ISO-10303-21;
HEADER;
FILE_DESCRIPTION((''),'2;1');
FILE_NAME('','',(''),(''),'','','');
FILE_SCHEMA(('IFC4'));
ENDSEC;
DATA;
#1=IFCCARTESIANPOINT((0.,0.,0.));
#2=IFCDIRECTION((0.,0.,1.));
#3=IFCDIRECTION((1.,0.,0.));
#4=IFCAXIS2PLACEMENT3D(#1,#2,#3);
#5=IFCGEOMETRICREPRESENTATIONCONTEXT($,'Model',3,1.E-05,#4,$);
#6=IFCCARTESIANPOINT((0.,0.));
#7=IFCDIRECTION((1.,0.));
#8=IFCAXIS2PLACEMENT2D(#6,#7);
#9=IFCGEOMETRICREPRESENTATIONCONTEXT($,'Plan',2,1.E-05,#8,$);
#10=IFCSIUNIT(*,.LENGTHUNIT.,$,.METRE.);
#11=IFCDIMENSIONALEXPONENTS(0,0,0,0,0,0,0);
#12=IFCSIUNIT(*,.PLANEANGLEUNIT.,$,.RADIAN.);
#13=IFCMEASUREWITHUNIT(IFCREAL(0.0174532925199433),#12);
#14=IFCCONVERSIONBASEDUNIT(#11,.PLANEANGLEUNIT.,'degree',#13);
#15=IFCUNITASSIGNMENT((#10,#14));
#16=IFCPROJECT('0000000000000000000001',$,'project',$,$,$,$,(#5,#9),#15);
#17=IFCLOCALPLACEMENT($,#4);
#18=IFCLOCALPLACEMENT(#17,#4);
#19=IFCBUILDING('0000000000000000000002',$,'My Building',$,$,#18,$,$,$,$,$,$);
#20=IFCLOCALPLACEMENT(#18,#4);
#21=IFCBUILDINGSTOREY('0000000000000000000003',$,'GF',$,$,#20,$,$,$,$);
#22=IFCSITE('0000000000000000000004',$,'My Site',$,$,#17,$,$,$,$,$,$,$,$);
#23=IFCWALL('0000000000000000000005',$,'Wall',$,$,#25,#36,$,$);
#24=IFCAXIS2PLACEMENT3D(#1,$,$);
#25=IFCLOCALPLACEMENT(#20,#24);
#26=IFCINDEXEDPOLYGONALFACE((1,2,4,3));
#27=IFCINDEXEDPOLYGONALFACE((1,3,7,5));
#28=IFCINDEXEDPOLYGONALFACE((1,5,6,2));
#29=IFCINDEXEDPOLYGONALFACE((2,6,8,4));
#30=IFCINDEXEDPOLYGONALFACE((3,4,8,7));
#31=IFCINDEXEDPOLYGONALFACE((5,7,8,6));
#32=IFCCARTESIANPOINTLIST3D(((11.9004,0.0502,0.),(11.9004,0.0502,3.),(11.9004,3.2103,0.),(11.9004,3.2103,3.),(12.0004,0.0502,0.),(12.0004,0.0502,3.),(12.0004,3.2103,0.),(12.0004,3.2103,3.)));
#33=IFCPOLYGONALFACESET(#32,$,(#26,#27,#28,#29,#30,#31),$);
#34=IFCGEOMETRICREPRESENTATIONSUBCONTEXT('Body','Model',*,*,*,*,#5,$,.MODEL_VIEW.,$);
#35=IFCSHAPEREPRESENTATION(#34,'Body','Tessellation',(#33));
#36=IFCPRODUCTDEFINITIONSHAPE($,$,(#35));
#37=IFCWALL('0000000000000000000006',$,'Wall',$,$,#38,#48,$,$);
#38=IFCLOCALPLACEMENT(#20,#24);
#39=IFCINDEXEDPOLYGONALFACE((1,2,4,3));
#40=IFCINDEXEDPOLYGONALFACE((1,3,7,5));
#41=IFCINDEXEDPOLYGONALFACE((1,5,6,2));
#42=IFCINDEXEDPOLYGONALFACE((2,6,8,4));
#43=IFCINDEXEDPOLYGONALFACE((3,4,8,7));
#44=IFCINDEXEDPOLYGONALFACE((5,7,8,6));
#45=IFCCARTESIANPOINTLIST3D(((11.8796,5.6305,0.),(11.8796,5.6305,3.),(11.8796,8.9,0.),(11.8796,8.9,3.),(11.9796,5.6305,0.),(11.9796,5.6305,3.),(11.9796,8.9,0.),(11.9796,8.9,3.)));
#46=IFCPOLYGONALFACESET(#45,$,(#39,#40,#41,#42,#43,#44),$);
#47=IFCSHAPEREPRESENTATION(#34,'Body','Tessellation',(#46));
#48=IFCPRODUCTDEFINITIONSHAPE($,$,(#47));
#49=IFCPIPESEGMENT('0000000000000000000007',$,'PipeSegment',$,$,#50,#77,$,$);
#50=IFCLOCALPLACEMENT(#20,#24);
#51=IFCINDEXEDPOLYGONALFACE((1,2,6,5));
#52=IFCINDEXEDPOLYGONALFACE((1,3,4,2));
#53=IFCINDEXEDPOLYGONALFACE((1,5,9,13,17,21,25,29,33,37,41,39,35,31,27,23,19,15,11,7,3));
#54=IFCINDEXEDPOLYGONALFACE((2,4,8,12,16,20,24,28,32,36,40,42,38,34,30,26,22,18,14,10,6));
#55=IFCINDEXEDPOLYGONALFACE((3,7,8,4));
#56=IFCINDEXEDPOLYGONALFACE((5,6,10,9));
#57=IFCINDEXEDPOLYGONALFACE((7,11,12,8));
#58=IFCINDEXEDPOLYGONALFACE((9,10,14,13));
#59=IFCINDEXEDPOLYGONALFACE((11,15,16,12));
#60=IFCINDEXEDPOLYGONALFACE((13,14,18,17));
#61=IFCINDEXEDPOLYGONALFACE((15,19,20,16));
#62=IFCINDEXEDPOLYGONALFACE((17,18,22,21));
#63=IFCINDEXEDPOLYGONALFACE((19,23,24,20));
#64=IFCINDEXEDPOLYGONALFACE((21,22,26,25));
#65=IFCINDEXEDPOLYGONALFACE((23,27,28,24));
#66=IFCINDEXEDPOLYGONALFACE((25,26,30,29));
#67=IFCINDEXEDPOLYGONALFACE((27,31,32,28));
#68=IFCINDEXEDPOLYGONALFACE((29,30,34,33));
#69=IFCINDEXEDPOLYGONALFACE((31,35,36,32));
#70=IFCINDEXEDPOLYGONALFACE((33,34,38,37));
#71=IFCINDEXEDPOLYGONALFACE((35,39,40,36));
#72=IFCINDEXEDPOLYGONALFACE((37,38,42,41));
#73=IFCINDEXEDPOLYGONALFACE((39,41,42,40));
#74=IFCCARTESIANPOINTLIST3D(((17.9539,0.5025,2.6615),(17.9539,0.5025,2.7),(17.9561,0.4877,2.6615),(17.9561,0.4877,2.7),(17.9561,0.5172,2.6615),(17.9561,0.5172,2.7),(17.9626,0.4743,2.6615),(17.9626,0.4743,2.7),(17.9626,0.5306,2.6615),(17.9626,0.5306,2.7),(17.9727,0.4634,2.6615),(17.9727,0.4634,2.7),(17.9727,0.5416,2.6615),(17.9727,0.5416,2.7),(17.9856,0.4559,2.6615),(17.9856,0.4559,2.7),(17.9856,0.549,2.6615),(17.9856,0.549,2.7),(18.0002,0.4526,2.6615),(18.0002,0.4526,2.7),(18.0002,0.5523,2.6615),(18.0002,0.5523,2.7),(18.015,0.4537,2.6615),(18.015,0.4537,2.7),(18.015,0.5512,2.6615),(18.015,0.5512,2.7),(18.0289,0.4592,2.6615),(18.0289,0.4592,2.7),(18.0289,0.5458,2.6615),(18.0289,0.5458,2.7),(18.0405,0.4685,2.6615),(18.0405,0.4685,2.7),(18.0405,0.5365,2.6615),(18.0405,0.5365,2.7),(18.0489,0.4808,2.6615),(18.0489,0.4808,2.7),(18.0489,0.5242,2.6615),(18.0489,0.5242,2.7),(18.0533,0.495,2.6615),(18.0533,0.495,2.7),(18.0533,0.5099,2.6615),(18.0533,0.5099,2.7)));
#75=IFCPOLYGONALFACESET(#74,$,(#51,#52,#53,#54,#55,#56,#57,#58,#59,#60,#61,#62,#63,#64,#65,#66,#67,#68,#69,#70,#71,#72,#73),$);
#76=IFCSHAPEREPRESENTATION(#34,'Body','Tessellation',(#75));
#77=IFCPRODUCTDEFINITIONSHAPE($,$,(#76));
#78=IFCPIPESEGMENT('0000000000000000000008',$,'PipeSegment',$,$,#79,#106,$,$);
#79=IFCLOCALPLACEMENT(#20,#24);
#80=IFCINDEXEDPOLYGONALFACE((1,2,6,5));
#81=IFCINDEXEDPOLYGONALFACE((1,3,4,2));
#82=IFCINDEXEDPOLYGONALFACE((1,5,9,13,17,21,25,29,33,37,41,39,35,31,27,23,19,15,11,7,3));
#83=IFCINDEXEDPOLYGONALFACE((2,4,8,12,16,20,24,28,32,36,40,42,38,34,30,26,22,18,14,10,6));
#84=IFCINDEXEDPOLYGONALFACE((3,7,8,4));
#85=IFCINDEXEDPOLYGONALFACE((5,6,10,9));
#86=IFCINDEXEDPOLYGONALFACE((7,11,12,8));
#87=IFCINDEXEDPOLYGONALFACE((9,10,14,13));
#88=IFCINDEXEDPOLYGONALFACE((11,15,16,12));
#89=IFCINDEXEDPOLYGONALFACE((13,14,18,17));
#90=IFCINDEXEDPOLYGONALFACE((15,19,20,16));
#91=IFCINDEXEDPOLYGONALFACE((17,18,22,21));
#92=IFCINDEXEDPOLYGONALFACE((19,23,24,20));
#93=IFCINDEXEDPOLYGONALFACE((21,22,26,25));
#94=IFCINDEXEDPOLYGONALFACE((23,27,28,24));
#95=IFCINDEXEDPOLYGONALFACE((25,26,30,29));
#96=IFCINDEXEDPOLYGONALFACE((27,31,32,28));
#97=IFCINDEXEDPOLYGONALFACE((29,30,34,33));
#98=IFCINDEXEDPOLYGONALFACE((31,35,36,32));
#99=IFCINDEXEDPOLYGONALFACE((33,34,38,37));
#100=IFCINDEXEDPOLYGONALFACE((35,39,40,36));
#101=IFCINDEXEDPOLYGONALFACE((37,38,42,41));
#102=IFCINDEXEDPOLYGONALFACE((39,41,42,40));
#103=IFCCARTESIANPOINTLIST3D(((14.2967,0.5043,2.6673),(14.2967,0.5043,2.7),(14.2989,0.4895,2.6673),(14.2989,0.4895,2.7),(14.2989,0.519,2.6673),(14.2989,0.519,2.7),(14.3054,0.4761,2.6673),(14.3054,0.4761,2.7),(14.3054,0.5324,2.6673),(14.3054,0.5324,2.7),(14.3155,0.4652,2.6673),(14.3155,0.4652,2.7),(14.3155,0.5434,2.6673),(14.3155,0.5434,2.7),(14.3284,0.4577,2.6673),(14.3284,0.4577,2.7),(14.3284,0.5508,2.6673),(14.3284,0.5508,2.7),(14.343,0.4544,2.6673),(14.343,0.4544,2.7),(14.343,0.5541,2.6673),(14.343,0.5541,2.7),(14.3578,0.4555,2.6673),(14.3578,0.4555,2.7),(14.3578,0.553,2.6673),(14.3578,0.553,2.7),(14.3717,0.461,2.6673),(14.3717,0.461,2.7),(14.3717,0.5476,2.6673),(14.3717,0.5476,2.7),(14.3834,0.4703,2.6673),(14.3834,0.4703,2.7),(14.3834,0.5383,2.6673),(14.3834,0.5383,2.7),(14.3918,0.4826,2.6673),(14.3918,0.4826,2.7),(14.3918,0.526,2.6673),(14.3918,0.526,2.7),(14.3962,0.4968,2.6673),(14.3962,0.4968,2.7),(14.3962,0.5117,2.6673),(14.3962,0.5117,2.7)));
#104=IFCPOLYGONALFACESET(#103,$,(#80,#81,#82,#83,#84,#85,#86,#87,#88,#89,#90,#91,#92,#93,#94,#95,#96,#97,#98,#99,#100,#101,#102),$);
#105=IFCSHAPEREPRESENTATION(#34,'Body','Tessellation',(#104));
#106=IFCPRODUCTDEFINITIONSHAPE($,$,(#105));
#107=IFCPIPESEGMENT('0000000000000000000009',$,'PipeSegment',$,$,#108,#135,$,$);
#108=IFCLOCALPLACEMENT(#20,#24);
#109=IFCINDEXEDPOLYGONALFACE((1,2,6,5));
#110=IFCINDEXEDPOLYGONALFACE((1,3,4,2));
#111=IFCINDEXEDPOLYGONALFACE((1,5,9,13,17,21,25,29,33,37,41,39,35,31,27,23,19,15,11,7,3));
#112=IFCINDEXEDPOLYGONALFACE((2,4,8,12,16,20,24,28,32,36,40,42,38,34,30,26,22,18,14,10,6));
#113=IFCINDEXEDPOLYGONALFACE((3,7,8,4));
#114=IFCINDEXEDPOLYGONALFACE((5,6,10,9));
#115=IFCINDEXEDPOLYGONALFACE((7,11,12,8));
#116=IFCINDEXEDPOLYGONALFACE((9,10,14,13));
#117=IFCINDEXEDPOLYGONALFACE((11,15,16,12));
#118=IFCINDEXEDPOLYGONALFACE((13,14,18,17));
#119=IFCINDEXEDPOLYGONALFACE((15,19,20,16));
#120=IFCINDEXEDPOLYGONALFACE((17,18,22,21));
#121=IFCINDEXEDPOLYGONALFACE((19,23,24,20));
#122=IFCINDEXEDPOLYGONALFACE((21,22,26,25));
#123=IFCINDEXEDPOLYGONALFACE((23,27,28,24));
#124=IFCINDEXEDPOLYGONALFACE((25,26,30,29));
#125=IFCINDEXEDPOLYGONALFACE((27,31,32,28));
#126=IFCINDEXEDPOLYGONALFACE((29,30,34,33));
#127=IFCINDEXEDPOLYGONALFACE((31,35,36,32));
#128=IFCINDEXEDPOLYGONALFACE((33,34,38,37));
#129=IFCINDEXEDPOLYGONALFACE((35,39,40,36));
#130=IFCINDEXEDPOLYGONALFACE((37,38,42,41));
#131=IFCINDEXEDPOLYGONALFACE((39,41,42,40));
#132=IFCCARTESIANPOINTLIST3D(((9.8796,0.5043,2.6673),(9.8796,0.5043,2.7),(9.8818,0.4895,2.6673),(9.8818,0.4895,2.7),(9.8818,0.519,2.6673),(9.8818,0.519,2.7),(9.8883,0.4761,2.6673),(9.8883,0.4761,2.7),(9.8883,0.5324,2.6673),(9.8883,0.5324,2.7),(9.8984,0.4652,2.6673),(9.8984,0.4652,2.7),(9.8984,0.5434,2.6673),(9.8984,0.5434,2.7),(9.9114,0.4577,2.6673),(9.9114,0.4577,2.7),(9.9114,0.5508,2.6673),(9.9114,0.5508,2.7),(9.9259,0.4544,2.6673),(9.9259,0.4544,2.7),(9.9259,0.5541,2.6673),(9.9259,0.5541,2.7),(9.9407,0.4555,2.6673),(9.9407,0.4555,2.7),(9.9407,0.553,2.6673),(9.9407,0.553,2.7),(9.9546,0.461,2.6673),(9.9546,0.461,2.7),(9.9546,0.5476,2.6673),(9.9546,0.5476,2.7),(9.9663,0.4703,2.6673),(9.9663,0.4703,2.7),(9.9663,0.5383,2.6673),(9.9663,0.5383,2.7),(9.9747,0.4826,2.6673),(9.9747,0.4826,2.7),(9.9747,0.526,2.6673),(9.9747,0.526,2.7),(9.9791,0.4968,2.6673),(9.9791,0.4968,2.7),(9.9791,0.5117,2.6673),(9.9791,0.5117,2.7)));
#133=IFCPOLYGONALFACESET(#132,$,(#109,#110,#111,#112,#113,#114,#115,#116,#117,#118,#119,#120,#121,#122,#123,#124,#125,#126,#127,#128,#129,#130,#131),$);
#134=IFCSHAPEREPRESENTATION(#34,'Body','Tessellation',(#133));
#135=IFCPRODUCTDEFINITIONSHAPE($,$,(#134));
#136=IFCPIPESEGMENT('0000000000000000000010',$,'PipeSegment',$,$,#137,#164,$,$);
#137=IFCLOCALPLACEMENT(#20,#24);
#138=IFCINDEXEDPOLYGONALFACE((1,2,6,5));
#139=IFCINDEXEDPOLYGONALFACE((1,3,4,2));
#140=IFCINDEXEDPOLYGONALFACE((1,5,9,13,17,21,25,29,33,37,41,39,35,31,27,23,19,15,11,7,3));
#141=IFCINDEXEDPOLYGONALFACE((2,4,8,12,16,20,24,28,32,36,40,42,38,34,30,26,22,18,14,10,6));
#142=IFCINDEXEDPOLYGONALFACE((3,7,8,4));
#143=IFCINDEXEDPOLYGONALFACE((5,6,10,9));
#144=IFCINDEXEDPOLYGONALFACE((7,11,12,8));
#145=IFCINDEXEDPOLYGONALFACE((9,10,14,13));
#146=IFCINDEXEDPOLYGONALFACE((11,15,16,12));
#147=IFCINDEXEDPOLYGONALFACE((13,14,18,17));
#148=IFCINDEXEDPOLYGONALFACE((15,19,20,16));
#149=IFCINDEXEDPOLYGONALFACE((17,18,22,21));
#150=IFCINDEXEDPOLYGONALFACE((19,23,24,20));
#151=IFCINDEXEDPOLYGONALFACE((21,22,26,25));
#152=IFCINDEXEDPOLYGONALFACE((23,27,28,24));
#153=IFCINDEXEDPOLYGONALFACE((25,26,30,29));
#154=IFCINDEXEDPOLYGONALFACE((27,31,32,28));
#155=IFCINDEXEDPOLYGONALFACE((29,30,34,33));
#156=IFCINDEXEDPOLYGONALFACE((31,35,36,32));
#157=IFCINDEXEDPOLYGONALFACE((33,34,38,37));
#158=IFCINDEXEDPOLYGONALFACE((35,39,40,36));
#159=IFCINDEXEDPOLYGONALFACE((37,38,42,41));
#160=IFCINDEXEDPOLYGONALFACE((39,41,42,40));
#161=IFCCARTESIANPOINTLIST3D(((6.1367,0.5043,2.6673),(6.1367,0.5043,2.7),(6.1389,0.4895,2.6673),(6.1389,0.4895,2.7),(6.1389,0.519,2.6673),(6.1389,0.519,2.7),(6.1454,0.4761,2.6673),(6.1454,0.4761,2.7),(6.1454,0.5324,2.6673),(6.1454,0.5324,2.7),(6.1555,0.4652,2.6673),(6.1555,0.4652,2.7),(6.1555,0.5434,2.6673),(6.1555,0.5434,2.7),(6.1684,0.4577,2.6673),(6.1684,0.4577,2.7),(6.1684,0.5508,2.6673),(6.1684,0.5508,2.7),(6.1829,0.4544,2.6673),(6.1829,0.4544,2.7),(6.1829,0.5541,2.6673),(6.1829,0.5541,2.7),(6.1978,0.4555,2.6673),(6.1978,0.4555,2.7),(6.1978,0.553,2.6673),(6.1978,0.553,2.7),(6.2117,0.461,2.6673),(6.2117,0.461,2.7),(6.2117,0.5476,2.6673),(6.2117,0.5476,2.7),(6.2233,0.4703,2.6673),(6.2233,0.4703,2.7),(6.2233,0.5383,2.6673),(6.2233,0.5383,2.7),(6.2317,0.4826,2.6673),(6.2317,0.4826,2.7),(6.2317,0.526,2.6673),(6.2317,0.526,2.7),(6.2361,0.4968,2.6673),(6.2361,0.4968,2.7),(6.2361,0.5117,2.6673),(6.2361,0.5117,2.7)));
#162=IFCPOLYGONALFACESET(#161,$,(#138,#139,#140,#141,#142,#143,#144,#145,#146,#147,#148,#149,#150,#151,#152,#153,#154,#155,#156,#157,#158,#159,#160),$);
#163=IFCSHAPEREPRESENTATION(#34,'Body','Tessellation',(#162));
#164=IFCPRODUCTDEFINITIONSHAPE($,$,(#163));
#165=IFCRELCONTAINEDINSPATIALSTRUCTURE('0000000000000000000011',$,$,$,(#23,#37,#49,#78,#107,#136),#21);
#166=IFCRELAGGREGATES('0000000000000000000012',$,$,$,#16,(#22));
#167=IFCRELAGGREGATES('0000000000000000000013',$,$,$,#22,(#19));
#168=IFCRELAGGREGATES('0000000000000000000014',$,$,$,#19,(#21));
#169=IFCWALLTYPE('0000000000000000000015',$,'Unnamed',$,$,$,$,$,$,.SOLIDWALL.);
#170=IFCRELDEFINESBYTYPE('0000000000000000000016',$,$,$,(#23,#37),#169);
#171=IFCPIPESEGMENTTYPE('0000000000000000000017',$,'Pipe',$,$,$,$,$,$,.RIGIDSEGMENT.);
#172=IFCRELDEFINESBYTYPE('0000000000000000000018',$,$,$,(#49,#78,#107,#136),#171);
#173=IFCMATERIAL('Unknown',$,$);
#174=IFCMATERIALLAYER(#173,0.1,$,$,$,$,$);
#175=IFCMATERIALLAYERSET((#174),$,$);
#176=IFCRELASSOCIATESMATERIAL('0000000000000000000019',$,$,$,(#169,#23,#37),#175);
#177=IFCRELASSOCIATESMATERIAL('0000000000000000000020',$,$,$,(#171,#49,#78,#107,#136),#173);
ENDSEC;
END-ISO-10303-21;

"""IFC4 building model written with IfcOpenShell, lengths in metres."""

from ifc_helpers import new_model, entity, si_unit, converted_unit, frame, origin_with_axes, origin_2d_with_axis, place, context, subcontext, project, spatial, line, indexed_curve, circle, outline, extrude, material, layer, layer_set, layer_usage, material_profile, profile_set, profile_usage, type_object, element, save


model = new_model("IFC4")

# Units and contexts
model_context = context("Model", 3, precision=1e-05, world=origin_with_axes())
plan_context = context("Plan", 2, precision=1e-05, world=origin_2d_with_axis())
body_context_1 = subcontext(model_context, "Body", "Model", "MODEL_VIEW")
ifc_project = project(units=[si_unit("LENGTHUNIT", "METRE"), converted_unit("PLANEANGLEUNIT", "degree", entity("IfcReal", 0.0174532925199433), si_unit("PLANEANGLEUNIT", "RADIAN"), dimensions=[0, 0, 0, 0, 0, 0, 0])], contexts=[model_context, plan_context])

# Site, building, storey
site_placement = place(None, origin_with_axes())
site = spatial("IfcSite", under=ifc_project, at=site_placement, Name="My Site")
building_placement = place(site_placement, origin_with_axes())
building = spatial("IfcBuilding", under=site, at=building_placement, Name="My Building")
storey_placement = place(building_placement, origin_with_axes())
storey = spatial("IfcBuildingStorey", under=building, at=storey_placement, Name="GF")

# Shared definitions
ifc_material = material(Name="Unknown")
ifc_layer = layer(ifc_material, 0.1)
ifc_layer_set = layer_set([ifc_layer])
wall_type = type_object("IfcWallType", Name="Unnamed", PredefinedType="SOLIDWALL", material=ifc_layer_set)

# Walls
ifc_layer_usage_1 = layer_usage(ifc_layer_set, "AXIS2", "POSITIVE", 0.0)
wall_1_placement = place(storey_placement, frame((12.0004, 0.0502, 0.0), z_axis=(0.0, 0.0, 1.0), x_axis=(0.000013, 1.0, 0.0)))
element("IfcWall", 1, at=wall_1_placement, inside=storey, type_object=wall_type, material=ifc_layer_usage_1, Name="Wall", context=body_context_1, shape_type="SweptSolid", body=[
    extrude(outline(indexed_curve([(0.0, 0.0), (0.0, 0.1), (3.1602, 0.1), (3.1602, 0.0)], segments=[line(1, 2, 3, 4, 1)])), origin_with_axes(), (0.0, 0.0, 1.0), 3.0),
])
ifc_layer_usage_2 = layer_usage(ifc_layer_set, "AXIS2", "POSITIVE", 0.0)
wall_2_placement = place(storey_placement, frame((11.9796, 5.6305, 0.0), z_axis=(0.0, 0.0, 1.0), x_axis=(0.0, 1.0, 0.0)))
element("IfcWall", 2, at=wall_2_placement, inside=storey, type_object=wall_type, material=ifc_layer_usage_2, Name="Wall", context=body_context_1, shape_type="SweptSolid", body=[
    extrude(outline(indexed_curve([(0.0, 0.0), (0.0, 0.1), (3.2695, 0.1), (3.2695, 0.0)], segments=[line(1, 2, 3, 4, 1)])), origin_with_axes(), (0.0, 0.0, 1.0), 3.0),
])

# Pipe segments
ifc_material_profile = material_profile(ifc_material, circle(Radius=0.05))
ifc_profile_set = profile_set([ifc_material_profile])
ifc_profile_usage_1 = profile_usage(ifc_profile_set, cardinal=5)
pipe_segment_type = type_object("IfcPipeSegmentType", Name="Pipe", PredefinedType="RIGIDSEGMENT", material=ifc_profile_set)
pipe_segment_1_placement = place(storey_placement, frame((18.0039, 0.5025, 2.7), z_axis=(0.0, 0.0, -1.0), x_axis=(-1.0, 0.0, 0.0)))
element("IfcPipeSegment", 3, at=pipe_segment_1_placement, inside=storey, type_object=pipe_segment_type, material=ifc_profile_usage_1, Name="PipeSegment", context=body_context_1, shape_type="SweptSolid", body=[
    extrude(circle(Radius=0.05), origin_with_axes(), (0.0, 0.0, 1.0), 0.0386),
])
ifc_profile_usage_2 = profile_usage(ifc_profile_set, cardinal=5)
pipe_segment_2_placement = place(storey_placement, frame((14.3467, 0.5043, 2.7), z_axis=(0.0, 0.0, -1.0), x_axis=(-1.0, 0.0, 0.0)))
element("IfcPipeSegment", 4, at=pipe_segment_2_placement, inside=storey, type_object=pipe_segment_type, material=ifc_profile_usage_2, Name="PipeSegment", context=body_context_1, shape_type="SweptSolid", body=[
    extrude(circle(Radius=0.05), origin_with_axes(), (0.0, 0.0, 1.0), 0.0328),
])
ifc_profile_usage_3 = profile_usage(ifc_profile_set, cardinal=5)
pipe_segment_3_placement = place(storey_placement, frame((9.9296, 0.5043, 2.7), z_axis=(0.0, 0.0, -1.0), x_axis=(-1.0, 0.0, 0.0)))
element("IfcPipeSegment", 5, at=pipe_segment_3_placement, inside=storey, type_object=pipe_segment_type, material=ifc_profile_usage_3, Name="PipeSegment", context=body_context_1, shape_type="SweptSolid", body=[
    extrude(circle(Radius=0.05), origin_with_axes(), (0.0, 0.0, 1.0), 0.0328),
])
ifc_profile_usage_4 = profile_usage(ifc_profile_set, cardinal=5)
pipe_segment_4_placement = place(storey_placement, frame((6.1867, 0.5043, 2.7), z_axis=(0.0, 0.0, -1.0), x_axis=(-1.0, 0.0, 0.0)))
element("IfcPipeSegment", 6, at=pipe_segment_4_placement, inside=storey, type_object=pipe_segment_type, material=ifc_profile_usage_4, Name="PipeSegment", context=body_context_1, shape_type="SweptSolid", body=[
    extrude(circle(Radius=0.05), origin_with_axes(), (0.0, 0.0, 1.0), 0.0328),
])

save(model, "model.ifc")
